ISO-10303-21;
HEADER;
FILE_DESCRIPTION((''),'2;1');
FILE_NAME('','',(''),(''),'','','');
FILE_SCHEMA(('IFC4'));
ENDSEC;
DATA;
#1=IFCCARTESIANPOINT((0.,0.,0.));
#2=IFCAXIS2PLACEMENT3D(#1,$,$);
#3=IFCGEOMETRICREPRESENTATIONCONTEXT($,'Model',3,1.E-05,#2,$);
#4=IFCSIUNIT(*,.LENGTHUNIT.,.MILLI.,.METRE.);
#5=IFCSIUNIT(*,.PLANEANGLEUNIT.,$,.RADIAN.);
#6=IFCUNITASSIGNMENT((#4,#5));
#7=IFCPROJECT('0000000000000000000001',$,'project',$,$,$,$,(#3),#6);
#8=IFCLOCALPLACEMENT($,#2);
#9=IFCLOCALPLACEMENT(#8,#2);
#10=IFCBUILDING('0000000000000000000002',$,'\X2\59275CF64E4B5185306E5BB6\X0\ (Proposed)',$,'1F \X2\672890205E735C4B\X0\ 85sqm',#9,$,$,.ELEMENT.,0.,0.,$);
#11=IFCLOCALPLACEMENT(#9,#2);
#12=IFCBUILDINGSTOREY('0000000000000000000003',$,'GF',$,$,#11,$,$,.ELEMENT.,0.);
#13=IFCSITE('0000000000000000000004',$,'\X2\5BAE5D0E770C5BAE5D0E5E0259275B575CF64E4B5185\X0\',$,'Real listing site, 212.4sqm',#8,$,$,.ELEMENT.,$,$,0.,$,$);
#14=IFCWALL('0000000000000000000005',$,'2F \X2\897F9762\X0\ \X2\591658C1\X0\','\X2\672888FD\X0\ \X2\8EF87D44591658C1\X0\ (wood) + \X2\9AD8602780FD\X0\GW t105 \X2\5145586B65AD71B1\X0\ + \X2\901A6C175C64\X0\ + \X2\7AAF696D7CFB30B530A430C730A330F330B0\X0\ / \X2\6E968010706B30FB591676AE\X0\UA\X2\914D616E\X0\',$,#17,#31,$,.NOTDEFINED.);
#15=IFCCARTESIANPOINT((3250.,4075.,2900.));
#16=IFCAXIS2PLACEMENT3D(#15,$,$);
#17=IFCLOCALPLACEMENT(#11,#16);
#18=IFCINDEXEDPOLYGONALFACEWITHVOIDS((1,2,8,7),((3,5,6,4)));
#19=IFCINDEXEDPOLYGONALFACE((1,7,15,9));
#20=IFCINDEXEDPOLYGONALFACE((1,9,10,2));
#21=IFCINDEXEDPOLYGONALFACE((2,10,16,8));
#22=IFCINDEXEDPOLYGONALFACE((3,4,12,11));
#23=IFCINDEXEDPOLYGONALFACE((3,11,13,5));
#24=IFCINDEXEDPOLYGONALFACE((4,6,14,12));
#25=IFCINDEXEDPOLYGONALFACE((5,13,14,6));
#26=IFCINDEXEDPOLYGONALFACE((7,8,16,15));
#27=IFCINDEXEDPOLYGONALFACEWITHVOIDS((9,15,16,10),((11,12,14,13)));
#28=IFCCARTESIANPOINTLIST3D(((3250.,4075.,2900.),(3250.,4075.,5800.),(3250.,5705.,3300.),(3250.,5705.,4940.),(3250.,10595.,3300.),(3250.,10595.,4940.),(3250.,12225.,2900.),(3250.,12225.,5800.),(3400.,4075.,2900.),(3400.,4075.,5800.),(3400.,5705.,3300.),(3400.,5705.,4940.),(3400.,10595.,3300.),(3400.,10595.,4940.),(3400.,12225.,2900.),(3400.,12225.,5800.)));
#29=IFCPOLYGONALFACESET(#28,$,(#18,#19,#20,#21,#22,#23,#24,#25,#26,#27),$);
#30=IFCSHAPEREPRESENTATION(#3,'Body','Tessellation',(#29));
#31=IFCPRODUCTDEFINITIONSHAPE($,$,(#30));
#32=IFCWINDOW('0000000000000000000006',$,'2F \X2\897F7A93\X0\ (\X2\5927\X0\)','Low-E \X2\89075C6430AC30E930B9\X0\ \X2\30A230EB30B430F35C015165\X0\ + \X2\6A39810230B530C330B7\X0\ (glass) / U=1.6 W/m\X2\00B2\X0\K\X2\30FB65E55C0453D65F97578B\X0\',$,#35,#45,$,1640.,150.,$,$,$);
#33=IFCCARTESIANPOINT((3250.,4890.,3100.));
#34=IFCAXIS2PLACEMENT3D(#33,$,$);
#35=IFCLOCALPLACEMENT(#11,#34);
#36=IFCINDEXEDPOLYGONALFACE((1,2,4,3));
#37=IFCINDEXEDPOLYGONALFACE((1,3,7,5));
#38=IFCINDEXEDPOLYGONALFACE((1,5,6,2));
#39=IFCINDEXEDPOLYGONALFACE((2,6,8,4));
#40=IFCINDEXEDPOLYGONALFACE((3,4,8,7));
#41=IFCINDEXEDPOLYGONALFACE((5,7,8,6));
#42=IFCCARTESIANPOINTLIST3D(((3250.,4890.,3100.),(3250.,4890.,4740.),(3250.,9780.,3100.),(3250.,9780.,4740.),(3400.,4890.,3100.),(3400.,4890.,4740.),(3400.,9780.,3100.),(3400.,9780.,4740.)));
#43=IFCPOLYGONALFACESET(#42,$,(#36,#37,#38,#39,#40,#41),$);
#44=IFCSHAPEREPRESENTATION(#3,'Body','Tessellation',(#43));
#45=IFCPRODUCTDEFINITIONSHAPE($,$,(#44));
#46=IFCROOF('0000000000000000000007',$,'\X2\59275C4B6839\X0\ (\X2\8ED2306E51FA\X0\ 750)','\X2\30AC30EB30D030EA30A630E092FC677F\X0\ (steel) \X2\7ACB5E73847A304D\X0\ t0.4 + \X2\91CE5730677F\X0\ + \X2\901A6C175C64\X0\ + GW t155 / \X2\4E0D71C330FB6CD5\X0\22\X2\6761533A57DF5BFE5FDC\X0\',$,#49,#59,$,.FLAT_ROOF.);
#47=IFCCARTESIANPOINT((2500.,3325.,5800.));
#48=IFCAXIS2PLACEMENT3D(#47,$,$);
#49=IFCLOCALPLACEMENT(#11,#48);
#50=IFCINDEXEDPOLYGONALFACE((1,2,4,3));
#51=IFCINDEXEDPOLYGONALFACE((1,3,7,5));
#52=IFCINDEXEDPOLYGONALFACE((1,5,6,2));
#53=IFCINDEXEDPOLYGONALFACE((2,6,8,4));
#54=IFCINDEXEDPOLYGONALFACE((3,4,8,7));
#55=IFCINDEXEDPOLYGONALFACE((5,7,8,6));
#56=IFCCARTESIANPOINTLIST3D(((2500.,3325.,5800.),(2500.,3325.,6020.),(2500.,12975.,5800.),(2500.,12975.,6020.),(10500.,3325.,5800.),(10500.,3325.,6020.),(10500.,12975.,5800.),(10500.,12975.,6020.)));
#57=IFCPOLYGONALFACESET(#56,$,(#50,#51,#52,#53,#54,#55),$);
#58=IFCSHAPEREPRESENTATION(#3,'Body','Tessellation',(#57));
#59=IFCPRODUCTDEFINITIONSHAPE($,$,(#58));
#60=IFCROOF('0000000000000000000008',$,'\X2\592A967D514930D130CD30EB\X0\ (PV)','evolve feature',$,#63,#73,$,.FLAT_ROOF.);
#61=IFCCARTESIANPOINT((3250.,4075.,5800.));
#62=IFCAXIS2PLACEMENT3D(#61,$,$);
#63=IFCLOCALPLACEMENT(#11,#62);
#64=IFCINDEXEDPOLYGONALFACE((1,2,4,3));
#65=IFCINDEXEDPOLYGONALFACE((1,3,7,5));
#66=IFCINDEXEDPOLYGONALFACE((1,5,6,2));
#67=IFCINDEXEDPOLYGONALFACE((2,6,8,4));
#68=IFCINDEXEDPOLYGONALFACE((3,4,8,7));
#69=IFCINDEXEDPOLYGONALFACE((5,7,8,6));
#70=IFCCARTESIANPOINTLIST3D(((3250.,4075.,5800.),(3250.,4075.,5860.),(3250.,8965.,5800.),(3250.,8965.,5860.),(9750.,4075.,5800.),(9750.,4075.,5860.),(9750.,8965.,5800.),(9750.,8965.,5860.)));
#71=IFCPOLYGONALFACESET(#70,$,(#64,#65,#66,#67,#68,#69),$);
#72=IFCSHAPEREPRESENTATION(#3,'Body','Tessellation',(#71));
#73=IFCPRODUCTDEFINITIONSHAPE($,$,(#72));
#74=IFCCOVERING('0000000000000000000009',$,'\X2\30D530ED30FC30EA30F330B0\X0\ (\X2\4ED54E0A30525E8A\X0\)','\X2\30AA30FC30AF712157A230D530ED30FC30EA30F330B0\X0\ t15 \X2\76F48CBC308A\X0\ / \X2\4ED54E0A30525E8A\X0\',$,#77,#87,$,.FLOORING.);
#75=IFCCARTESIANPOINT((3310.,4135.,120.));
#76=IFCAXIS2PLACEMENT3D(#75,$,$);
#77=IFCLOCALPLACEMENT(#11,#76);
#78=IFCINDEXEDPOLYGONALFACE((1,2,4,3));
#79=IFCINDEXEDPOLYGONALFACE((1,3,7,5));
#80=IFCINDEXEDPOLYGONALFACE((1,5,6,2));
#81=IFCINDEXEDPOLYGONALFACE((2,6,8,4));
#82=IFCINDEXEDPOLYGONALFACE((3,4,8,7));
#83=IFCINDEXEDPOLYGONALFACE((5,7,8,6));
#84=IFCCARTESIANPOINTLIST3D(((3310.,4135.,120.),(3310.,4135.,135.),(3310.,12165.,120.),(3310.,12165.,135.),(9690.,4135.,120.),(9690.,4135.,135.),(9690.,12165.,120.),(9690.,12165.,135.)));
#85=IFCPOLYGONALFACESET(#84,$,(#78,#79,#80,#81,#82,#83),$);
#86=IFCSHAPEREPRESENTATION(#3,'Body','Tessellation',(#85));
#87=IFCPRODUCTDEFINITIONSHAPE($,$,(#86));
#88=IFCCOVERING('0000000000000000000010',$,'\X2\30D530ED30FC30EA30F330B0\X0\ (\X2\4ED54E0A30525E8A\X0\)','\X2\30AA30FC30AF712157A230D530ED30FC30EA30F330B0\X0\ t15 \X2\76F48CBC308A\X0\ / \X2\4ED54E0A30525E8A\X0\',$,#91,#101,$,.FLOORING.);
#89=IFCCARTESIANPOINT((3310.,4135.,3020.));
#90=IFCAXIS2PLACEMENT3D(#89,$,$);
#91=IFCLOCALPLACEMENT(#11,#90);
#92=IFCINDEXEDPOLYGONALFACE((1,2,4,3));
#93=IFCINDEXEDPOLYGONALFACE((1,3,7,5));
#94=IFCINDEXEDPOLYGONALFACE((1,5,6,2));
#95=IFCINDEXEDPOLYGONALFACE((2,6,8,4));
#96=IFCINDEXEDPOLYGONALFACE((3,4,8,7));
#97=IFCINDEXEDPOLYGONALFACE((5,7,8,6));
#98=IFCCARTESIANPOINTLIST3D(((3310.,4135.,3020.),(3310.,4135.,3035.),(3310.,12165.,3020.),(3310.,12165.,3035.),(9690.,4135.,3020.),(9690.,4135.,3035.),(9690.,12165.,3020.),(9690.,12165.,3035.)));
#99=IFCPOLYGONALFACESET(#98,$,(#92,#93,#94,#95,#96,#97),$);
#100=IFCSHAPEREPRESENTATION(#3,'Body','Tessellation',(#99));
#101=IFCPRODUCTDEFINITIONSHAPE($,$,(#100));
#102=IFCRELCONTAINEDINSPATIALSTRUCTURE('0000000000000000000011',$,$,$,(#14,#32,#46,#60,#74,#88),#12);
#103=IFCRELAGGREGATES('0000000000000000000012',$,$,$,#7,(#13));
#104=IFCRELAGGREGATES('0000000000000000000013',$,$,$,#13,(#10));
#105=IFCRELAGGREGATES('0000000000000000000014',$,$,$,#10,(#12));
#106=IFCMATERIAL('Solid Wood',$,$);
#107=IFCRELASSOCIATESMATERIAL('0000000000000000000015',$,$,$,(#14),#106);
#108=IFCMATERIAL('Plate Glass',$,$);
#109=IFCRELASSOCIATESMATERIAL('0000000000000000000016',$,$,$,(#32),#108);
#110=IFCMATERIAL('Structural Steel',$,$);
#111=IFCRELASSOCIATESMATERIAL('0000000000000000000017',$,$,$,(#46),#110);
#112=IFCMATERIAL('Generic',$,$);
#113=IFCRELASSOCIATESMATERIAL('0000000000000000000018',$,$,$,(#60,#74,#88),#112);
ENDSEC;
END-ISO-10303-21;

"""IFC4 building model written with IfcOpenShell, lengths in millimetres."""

from ifc_helpers import new_model, si_unit, frame, frame_2d, origin, place, context, project, spatial, rectangle, extrude, material, element, fill, save


model = new_model("IFC4")

# Units and contexts
model_context = context("Model", 3, precision=1e-05, world=origin())
ifc_project = project(units=[si_unit("LENGTHUNIT", "METRE", prefix="MILLI"), si_unit("PLANEANGLEUNIT", "RADIAN")], contexts=[model_context])

# Site, building, storey
site_placement = place(None, origin())
site = spatial("IfcSite", under=ifc_project, at=site_placement, Name="宮崎県宮崎市大字島之内", ObjectType="Real listing site, 212.4sqm", CompositionType="ELEMENT", RefElevation=0.0)
building_placement = place(site_placement, origin())
building = spatial("IfcBuilding", under=site, at=building_placement, Name="大島之内の家 (Proposed)", ObjectType="1F 木造平屋 85sqm", CompositionType="ELEMENT", ElevationOfRefHeight=0.0, ElevationOfTerrain=0.0)
storey_placement = place(building_placement, origin())
storey = spatial("IfcBuildingStorey", under=building, at=storey_placement, Name="GF", CompositionType="ELEMENT", Elevation=0.0)

# Shared definitions
ifc_material_1 = material(Name="Solid Wood")
ifc_material_2 = material(Name="Generic")

# Shared definitions
ifc_material_3 = material(Name="Plate Glass")

# Wall, opening, window
wall_1_placement = place(storey_placement, frame((3250.0, 4075.0, 2900.0)))
wall_1 = element("IfcWall", 1, at=wall_1_placement, inside=storey, material=ifc_material_1, Name="2F 西面 外壁", Description="木製 軸組外壁 (wood) + 高性能GW t105 充填断熱 + 通気層 + 窯業系サイディング / 準耐火・外皮UA配慮", PredefinedType="NOTDEFINED", context=model_context, shape_type="SweptSolid", body=[
    extrude(rectangle(XDim=150.0, YDim=8150.0, at=frame_2d((75.0, 4075.0))), frame((3250.0, 4075.0, 2900.0)), (0.0, 0.0, 1.0), 2900.0),
])
opening_1_placement = place(storey_placement, frame((3250.0, 4890.0, 3100.0)))
opening_1 = element("IfcOpeningElement", 2, at=opening_1_placement, cuts=wall_1, PredefinedType="NOTDEFINED", context=model_context, shape_type="SweptSolid", body=[
    extrude(rectangle(XDim=150.0, YDim=4890.0, at=frame_2d((75.0, 2445.0))), frame((3250.0, 4890.0, 3100.0)), (0.0, 0.0, 1.0), 1640.0),
])
window_1_placement = place(storey_placement, frame((3250.0, 4890.0, 3100.0)))
window_1 = element("IfcWindow", 3, at=window_1_placement, inside=storey, material=ifc_material_3, Name="2F 西窓 (大)", Description="Low-E 複層ガラス アルゴン封入 + 樹脂サッシ (glass) / U=1.6 W/m²K・日射取得型", OverallHeight=1640.0, OverallWidth=150.0, context=model_context, shape_type="SweptSolid", body=[
    extrude(rectangle(XDim=150.0, YDim=4890.0, at=frame_2d((75.0, 2445.0))), frame((3250.0, 4890.0, 3100.0)), (0.0, 0.0, 1.0), 1640.0),
])
fill(opening_1, window_1)

# Roofs
ifc_material_4 = material(Name="Structural Steel")
roof_1_placement = place(storey_placement, frame((2500.0, 3325.0, 5800.0)))
element("IfcRoof", 4, at=roof_1_placement, inside=storey, material=ifc_material_4, Name="大屋根 (軒の出 750)", Description="ガルバリウム鋼板 (steel) 立平葺き t0.4 + 野地板 + 通気層 + GW t155 / 不燃・法22条区域対応", PredefinedType="FLAT_ROOF", context=model_context, shape_type="SweptSolid", body=[
    extrude(rectangle(XDim=8000.0, YDim=9650.0, at=frame_2d((4000.0, 4825.0))), frame((2500.0, 3325.0, 5800.0)), (0.0, 0.0, 1.0), 220.0),
])
roof_2_placement = place(storey_placement, frame((3250.0, 4075.0, 5800.0)))
element("IfcRoof", 5, at=roof_2_placement, inside=storey, material=ifc_material_2, Name="太陽光パネル (PV)", Description="evolve feature", PredefinedType="FLAT_ROOF", context=model_context, shape_type="SweptSolid", body=[
    extrude(rectangle(XDim=6500.0, YDim=4890.0, at=frame_2d((3250.0, 2445.0))), frame((3250.0, 4075.0, 5800.0)), (0.0, 0.0, 1.0), 60.0),
])

# Coverings
covering_1_placement = place(storey_placement, frame((3310.0, 4135.0, 120.0)))
element("IfcCovering", 6, at=covering_1_placement, inside=storey, material=ifc_material_2, Name="フローリング (仕上げ床)", Description="オーク無垢フローリング t15 直貼り / 仕上げ床", PredefinedType="FLOORING", context=model_context, shape_type="SweptSolid", body=[
    extrude(rectangle(XDim=6380.0, YDim=8030.0, at=frame_2d((3190.0, 4015.0))), frame((3310.0, 4135.0, 120.0)), (0.0, 0.0, 1.0), 15.0),
])
covering_2_placement = place(storey_placement, frame((3310.0, 4135.0, 3020.0)))
element("IfcCovering", 7, at=covering_2_placement, inside=storey, material=ifc_material_2, Name="フローリング (仕上げ床)", Description="オーク無垢フローリング t15 直貼り / 仕上げ床", PredefinedType="FLOORING", context=model_context, shape_type="SweptSolid", body=[
    extrude(rectangle(XDim=6380.0, YDim=8030.0, at=frame_2d((3190.0, 4015.0))), frame((3310.0, 4135.0, 3020.0)), (0.0, 0.0, 1.0), 15.0),
])

save(model, "model.ifc")
